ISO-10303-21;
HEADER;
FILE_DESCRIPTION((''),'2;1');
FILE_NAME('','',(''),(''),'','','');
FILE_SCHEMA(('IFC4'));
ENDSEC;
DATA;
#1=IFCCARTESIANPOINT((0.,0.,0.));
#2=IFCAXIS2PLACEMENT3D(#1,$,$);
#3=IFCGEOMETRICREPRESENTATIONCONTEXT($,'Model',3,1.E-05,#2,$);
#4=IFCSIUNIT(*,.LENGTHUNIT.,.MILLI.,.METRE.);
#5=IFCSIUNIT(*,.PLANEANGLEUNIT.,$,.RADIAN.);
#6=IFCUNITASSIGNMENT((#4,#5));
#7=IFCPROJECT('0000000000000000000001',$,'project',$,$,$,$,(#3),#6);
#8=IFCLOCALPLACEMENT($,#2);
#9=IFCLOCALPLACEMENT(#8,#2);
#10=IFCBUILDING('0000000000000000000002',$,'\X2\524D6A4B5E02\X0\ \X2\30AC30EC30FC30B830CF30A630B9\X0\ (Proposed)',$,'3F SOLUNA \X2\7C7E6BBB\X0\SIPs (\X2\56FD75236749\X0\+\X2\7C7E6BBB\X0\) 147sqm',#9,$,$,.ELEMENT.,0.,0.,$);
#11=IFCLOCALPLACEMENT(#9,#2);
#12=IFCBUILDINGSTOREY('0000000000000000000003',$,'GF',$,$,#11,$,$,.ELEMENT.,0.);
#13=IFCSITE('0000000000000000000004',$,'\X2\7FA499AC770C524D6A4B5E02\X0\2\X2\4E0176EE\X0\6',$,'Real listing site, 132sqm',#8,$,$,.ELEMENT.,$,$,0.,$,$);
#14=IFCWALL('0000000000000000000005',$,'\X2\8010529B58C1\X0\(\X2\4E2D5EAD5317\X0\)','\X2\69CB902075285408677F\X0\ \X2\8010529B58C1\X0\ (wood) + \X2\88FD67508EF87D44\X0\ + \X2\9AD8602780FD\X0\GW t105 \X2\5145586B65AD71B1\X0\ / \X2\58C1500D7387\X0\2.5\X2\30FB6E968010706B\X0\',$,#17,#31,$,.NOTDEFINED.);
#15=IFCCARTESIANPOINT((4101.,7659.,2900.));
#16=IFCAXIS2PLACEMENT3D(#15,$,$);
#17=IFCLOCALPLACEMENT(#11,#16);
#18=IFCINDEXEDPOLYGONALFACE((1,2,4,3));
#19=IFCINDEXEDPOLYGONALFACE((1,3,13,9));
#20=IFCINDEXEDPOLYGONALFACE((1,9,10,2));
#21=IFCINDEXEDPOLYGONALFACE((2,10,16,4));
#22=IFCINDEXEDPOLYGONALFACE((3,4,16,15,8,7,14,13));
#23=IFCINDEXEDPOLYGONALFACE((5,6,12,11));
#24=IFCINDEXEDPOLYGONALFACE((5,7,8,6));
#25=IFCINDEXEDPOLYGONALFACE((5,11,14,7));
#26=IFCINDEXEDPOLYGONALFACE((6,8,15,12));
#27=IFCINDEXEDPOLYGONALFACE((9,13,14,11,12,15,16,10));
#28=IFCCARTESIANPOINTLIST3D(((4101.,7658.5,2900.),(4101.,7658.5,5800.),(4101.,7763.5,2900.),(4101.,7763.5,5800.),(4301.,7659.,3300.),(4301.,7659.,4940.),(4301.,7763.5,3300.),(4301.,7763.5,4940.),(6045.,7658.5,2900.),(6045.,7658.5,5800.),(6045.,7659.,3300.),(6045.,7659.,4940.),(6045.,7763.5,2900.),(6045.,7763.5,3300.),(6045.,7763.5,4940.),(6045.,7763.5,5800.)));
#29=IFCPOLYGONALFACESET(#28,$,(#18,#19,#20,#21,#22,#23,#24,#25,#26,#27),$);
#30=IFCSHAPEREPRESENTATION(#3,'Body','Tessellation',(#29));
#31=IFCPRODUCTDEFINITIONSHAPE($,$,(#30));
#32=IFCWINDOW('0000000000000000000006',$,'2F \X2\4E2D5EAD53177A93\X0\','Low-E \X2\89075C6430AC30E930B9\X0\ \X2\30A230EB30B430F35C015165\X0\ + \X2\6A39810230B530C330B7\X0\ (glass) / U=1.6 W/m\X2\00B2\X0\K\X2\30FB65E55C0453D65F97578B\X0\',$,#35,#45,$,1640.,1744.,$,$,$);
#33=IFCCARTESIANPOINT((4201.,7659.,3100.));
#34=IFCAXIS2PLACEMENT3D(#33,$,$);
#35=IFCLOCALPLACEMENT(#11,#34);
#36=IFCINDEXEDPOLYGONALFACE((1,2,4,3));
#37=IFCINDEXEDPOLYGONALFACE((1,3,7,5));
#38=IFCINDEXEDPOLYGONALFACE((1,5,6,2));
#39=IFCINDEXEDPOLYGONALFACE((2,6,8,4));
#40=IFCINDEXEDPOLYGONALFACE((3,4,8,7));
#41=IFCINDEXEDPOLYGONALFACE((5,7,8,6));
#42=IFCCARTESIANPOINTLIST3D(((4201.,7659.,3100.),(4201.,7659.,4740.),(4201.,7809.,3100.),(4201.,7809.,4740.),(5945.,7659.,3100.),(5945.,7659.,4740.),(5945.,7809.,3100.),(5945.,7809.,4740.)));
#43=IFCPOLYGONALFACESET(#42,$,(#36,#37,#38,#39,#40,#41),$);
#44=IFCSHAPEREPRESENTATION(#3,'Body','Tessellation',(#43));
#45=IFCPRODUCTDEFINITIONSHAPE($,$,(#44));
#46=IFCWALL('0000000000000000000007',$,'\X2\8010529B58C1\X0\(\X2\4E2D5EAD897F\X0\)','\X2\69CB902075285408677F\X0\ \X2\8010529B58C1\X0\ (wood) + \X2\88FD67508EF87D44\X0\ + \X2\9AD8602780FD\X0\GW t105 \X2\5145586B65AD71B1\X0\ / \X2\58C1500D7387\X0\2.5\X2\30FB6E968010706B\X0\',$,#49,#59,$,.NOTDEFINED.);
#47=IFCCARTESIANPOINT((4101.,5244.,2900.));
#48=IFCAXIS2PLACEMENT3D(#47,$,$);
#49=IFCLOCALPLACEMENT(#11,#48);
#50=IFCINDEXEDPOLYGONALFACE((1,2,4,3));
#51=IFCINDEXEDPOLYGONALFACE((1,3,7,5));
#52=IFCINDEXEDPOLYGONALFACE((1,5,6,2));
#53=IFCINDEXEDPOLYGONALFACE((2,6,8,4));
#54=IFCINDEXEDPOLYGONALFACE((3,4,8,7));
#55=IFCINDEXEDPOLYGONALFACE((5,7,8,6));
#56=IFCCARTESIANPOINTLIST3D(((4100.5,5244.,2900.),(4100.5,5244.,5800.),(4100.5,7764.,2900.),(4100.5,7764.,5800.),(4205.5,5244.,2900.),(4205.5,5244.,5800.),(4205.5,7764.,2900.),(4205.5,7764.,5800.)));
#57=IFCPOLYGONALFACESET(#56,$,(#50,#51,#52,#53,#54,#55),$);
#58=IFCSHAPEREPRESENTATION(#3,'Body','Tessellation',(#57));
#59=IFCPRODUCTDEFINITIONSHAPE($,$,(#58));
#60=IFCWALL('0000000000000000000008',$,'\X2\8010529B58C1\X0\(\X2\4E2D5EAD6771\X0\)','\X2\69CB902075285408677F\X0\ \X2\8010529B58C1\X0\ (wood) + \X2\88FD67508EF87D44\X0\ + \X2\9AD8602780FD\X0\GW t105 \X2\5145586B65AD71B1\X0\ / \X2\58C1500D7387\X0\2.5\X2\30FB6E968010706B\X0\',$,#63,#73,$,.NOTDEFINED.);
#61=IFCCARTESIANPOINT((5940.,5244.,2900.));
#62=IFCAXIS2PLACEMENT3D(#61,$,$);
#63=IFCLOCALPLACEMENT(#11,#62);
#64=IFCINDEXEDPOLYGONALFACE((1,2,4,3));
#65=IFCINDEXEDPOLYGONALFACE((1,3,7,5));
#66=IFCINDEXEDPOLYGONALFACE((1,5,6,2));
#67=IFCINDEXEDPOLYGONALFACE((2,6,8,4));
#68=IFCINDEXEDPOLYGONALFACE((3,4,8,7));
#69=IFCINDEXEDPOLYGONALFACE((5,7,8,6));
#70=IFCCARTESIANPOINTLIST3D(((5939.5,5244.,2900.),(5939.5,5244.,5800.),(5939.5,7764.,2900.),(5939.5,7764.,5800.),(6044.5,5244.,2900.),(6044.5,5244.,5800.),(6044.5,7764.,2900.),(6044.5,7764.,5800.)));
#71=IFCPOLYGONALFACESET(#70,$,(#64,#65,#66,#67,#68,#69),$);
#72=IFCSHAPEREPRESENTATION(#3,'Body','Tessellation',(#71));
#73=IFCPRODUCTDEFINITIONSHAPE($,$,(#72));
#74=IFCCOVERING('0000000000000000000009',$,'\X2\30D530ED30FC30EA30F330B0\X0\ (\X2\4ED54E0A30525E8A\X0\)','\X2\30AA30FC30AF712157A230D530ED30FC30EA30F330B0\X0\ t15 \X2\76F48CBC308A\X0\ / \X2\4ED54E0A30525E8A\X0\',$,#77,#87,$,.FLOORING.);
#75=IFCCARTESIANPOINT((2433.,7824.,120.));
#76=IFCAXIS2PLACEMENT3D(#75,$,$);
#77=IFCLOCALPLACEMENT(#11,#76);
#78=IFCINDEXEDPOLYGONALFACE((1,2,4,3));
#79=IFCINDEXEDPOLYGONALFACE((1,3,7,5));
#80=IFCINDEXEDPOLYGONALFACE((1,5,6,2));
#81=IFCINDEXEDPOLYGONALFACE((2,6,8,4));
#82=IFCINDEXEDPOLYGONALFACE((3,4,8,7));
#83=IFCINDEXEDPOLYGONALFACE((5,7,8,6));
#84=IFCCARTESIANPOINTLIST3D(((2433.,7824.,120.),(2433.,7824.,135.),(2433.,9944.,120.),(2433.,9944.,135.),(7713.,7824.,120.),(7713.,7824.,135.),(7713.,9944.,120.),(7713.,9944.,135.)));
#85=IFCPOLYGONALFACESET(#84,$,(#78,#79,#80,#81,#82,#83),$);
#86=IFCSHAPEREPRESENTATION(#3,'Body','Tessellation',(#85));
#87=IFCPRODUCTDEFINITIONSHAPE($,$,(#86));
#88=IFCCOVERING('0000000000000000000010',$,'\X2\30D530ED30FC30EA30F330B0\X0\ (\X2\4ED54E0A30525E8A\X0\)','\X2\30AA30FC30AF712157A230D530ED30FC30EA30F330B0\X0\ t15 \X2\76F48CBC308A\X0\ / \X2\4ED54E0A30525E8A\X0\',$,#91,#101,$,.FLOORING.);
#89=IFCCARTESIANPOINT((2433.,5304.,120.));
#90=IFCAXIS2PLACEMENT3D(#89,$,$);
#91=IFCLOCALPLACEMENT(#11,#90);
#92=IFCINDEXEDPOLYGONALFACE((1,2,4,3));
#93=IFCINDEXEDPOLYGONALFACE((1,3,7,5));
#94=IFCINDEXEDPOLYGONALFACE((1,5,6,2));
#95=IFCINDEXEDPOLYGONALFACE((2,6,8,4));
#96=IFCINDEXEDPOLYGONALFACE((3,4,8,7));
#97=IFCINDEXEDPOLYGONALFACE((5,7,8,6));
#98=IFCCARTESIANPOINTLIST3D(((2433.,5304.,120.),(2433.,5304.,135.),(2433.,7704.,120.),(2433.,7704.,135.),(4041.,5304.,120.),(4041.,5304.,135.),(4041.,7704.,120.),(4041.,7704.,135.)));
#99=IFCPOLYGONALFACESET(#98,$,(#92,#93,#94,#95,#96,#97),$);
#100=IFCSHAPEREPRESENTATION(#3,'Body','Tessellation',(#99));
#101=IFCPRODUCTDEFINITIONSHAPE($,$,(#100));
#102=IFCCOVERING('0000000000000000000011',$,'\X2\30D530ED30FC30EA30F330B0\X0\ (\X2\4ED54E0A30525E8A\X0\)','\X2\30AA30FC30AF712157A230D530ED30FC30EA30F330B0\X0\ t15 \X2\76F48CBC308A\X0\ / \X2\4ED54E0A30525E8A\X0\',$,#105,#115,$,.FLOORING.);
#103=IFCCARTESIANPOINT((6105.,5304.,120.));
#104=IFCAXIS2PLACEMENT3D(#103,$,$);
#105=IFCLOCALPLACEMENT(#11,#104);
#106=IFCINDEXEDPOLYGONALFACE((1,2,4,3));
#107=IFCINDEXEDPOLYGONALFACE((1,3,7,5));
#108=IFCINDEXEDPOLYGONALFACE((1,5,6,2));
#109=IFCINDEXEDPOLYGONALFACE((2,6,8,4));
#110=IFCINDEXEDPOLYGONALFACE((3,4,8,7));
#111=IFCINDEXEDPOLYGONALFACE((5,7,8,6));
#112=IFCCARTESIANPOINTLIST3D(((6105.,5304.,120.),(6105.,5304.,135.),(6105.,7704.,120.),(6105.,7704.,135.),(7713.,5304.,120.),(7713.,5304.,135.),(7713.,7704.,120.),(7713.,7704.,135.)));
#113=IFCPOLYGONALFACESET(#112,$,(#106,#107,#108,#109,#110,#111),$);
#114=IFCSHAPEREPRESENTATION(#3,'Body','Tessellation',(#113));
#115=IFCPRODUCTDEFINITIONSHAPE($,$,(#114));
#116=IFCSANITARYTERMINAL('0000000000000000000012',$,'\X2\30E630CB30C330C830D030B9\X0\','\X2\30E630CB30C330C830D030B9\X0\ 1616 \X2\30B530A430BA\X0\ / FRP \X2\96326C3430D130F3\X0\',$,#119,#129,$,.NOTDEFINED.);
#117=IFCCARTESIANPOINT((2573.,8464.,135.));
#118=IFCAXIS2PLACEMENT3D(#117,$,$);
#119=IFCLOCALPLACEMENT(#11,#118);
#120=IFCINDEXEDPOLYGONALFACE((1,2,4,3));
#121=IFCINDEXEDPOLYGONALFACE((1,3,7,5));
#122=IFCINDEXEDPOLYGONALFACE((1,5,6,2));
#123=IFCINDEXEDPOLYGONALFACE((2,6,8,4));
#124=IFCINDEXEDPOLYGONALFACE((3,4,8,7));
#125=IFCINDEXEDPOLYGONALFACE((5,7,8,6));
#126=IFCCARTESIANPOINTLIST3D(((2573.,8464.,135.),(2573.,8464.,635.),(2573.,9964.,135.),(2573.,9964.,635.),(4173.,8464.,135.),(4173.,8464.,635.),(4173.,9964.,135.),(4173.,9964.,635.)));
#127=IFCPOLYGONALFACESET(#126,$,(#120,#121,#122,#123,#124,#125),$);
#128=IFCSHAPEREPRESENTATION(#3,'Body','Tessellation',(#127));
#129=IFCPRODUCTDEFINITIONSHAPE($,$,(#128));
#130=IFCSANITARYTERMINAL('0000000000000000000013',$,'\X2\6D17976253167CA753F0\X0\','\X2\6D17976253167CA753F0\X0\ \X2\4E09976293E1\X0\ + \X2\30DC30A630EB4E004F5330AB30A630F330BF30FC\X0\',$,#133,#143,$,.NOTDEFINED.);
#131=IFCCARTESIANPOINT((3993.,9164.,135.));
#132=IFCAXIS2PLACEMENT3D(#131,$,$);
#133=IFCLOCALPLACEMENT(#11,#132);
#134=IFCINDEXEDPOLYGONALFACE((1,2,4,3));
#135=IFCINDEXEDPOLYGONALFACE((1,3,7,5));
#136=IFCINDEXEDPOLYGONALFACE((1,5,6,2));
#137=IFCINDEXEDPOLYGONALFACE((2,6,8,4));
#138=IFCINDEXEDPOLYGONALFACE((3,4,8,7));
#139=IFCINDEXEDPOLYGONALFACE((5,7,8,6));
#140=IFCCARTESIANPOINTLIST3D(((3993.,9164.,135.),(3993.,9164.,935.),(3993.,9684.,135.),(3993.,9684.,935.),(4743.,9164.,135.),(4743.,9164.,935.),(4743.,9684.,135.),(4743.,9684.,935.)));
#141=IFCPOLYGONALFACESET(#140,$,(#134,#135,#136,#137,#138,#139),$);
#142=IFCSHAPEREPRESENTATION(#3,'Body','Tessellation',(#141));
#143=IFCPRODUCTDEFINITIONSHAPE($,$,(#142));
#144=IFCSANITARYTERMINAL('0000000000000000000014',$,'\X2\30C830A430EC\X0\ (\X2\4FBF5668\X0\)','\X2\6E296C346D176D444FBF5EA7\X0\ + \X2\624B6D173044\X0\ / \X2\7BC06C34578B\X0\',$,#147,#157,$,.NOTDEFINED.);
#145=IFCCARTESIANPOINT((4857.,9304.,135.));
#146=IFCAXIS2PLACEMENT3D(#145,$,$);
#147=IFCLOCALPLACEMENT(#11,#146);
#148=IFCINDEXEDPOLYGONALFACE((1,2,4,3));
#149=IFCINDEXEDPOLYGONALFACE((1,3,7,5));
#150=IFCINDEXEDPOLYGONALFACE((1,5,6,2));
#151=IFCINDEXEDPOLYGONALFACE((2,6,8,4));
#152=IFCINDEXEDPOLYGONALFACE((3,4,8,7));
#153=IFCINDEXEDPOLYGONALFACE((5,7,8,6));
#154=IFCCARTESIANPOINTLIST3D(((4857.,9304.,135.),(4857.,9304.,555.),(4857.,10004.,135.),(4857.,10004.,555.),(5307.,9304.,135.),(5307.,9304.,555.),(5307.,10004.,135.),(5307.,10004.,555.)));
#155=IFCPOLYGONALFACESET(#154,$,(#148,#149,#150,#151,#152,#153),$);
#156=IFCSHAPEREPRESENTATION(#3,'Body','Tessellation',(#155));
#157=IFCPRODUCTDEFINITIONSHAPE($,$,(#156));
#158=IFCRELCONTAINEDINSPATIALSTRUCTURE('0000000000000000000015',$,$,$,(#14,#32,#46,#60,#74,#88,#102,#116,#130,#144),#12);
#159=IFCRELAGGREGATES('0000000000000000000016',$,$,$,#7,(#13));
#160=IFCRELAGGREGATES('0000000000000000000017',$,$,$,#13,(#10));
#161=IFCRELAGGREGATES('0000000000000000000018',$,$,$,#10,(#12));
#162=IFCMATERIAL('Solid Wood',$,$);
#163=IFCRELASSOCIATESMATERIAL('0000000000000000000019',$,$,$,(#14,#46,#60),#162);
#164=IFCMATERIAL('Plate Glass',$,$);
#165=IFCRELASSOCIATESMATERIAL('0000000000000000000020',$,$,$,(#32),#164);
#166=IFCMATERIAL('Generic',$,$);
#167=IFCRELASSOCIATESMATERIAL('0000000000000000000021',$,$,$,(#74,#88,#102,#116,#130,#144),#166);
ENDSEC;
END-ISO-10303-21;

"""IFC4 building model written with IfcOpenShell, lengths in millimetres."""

from ifc_helpers import new_model, si_unit, frame, frame_2d, origin, place, context, project, spatial, rectangle, extrude, material, element, fill, save


model = new_model("IFC4")

# Units and contexts
model_context = context("Model", 3, precision=1e-05, world=origin())
ifc_project = project(units=[si_unit("LENGTHUNIT", "METRE", prefix="MILLI"), si_unit("PLANEANGLEUNIT", "RADIAN")], contexts=[model_context])

# Site, building, storey
site_placement = place(None, origin())
site = spatial("IfcSite", under=ifc_project, at=site_placement, Name="群馬県前橋市2丁目6", ObjectType="Real listing site, 132sqm", CompositionType="ELEMENT", RefElevation=0.0)
building_placement = place(site_placement, origin())
building = spatial("IfcBuilding", under=site, at=building_placement, Name="前橋市 ガレージハウス (Proposed)", ObjectType="3F SOLUNA 籾殻SIPs (国産杉+籾殻) 147sqm", CompositionType="ELEMENT", ElevationOfRefHeight=0.0, ElevationOfTerrain=0.0)
storey_placement = place(building_placement, origin())
storey = spatial("IfcBuildingStorey", under=building, at=storey_placement, Name="GF", CompositionType="ELEMENT", Elevation=0.0)

# Shared definitions
ifc_material_1 = material(Name="Solid Wood")

# Shared definitions
ifc_material_2 = material(Name="Plate Glass")

# Wall, opening, window
wall_1_placement = place(storey_placement, frame((4101.0, 7659.0, 2900.0)))
wall_1 = element("IfcWall", 1, at=wall_1_placement, inside=storey, material=ifc_material_1, Name="耐力壁(中庭北)", Description="構造用合板 耐力壁 (wood) + 製材軸組 + 高性能GW t105 充填断熱 / 壁倍率2.5・準耐火", PredefinedType="NOTDEFINED", context=model_context, shape_type="SweptSolid", body=[
    extrude(rectangle(XDim=1944.0, YDim=105.0, at=frame_2d((972.0, 52.0))), frame((4101.0, 7659.0, 2900.0)), (0.0, 0.0, 1.0), 2900.0),
])
opening_1_placement = place(storey_placement, frame((4201.0, 7659.0, 3100.0)))
opening_1 = element("IfcOpeningElement", 2, at=opening_1_placement, cuts=wall_1, PredefinedType="NOTDEFINED", context=model_context, shape_type="SweptSolid", body=[
    extrude(rectangle(XDim=1744.0, YDim=150.0, at=frame_2d((872.0, 75.0))), frame((4201.0, 7659.0, 3100.0)), (0.0, 0.0, 1.0), 1640.0),
])
window_1_placement = place(storey_placement, frame((4201.0, 7659.0, 3100.0)))
window_1 = element("IfcWindow", 3, at=window_1_placement, inside=storey, material=ifc_material_2, Name="2F 中庭北窓", Description="Low-E 複層ガラス アルゴン封入 + 樹脂サッシ (glass) / U=1.6 W/m²K・日射取得型", OverallHeight=1640.0, OverallWidth=1744.0, context=model_context, shape_type="SweptSolid", body=[
    extrude(rectangle(XDim=1744.0, YDim=150.0, at=frame_2d((872.0, 75.0))), frame((4201.0, 7659.0, 3100.0)), (0.0, 0.0, 1.0), 1640.0),
])
fill(opening_1, window_1)

# Walls
wall_2_placement = place(storey_placement, frame((4101.0, 5244.0, 2900.0)))
element("IfcWall", 4, at=wall_2_placement, inside=storey, material=ifc_material_1, Name="耐力壁(中庭西)", Description="構造用合板 耐力壁 (wood) + 製材軸組 + 高性能GW t105 充填断熱 / 壁倍率2.5・準耐火", PredefinedType="NOTDEFINED", context=model_context, shape_type="SweptSolid", body=[
    extrude(rectangle(XDim=105.0, YDim=2520.0, at=frame_2d((52.0, 1260.0))), frame((4101.0, 5244.0, 2900.0)), (0.0, 0.0, 1.0), 2900.0),
])
wall_3_placement = place(storey_placement, frame((5940.0, 5244.0, 2900.0)))
element("IfcWall", 5, at=wall_3_placement, inside=storey, material=ifc_material_1, Name="耐力壁(中庭東)", Description="構造用合板 耐力壁 (wood) + 製材軸組 + 高性能GW t105 充填断熱 / 壁倍率2.5・準耐火", PredefinedType="NOTDEFINED", context=model_context, shape_type="SweptSolid", body=[
    extrude(rectangle(XDim=105.0, YDim=2520.0, at=frame_2d((52.0, 1260.0))), frame((5940.0, 5244.0, 2900.0)), (0.0, 0.0, 1.0), 2900.0),
])

# Coverings
ifc_material_3 = material(Name="Generic")
covering_1_placement = place(storey_placement, frame((2433.0, 7824.0, 120.0)))
element("IfcCovering", 6, at=covering_1_placement, inside=storey, material=ifc_material_3, Name="フローリング (仕上げ床)", Description="オーク無垢フローリング t15 直貼り / 仕上げ床", PredefinedType="FLOORING", context=model_context, shape_type="SweptSolid", body=[
    extrude(rectangle(XDim=5280.0, YDim=2120.0, at=frame_2d((2640.0, 1060.0))), frame((2433.0, 7824.0, 120.0)), (0.0, 0.0, 1.0), 15.0),
])
covering_2_placement = place(storey_placement, frame((2433.0, 5304.0, 120.0)))
element("IfcCovering", 7, at=covering_2_placement, inside=storey, material=ifc_material_3, Name="フローリング (仕上げ床)", Description="オーク無垢フローリング t15 直貼り / 仕上げ床", PredefinedType="FLOORING", context=model_context, shape_type="SweptSolid", body=[
    extrude(rectangle(XDim=1608.0, YDim=2400.0, at=frame_2d((804.0, 1200.0))), frame((2433.0, 5304.0, 120.0)), (0.0, 0.0, 1.0), 15.0),
])
covering_3_placement = place(storey_placement, frame((6105.0, 5304.0, 120.0)))
element("IfcCovering", 8, at=covering_3_placement, inside=storey, material=ifc_material_3, Name="フローリング (仕上げ床)", Description="オーク無垢フローリング t15 直貼り / 仕上げ床", PredefinedType="FLOORING", context=model_context, shape_type="SweptSolid", body=[
    extrude(rectangle(XDim=1608.0, YDim=2400.0, at=frame_2d((804.0, 1200.0))), frame((6105.0, 5304.0, 120.0)), (0.0, 0.0, 1.0), 15.0),
])

# Sanitary terminals
sanitary_terminal_1_placement = place(storey_placement, frame((2573.0, 8464.0, 135.0)))
element("IfcSanitaryTerminal", 9, at=sanitary_terminal_1_placement, inside=storey, material=ifc_material_3, Name="ユニットバス", Description="ユニットバス 1616 サイズ / FRP 防水パン", PredefinedType="NOTDEFINED", context=model_context, shape_type="SweptSolid", body=[
    extrude(rectangle(XDim=1600.0, YDim=1500.0, at=frame_2d((800.0, 750.0))), frame((2573.0, 8464.0, 135.0)), (0.0, 0.0, 1.0), 500.0),
])
sanitary_terminal_2_placement = place(storey_placement, frame((3993.0, 9164.0, 135.0)))
element("IfcSanitaryTerminal", 10, at=sanitary_terminal_2_placement, inside=storey, material=ifc_material_3, Name="洗面化粧台", Description="洗面化粧台 三面鏡 + ボウル一体カウンター", PredefinedType="NOTDEFINED", context=model_context, shape_type="SweptSolid", body=[
    extrude(rectangle(XDim=750.0, YDim=520.0, at=frame_2d((375.0, 260.0))), frame((3993.0, 9164.0, 135.0)), (0.0, 0.0, 1.0), 800.0),
])
sanitary_terminal_3_placement = place(storey_placement, frame((4857.0, 9304.0, 135.0)))
element("IfcSanitaryTerminal", 11, at=sanitary_terminal_3_placement, inside=storey, material=ifc_material_3, Name="トイレ (便器)", Description="温水洗浄便座 + 手洗い / 節水型", PredefinedType="NOTDEFINED", context=model_context, shape_type="SweptSolid", body=[
    extrude(rectangle(XDim=450.0, YDim=700.0, at=frame_2d((225.0, 350.0))), frame((4857.0, 9304.0, 135.0)), (0.0, 0.0, 1.0), 420.0),
])

save(model, "model.ifc")
